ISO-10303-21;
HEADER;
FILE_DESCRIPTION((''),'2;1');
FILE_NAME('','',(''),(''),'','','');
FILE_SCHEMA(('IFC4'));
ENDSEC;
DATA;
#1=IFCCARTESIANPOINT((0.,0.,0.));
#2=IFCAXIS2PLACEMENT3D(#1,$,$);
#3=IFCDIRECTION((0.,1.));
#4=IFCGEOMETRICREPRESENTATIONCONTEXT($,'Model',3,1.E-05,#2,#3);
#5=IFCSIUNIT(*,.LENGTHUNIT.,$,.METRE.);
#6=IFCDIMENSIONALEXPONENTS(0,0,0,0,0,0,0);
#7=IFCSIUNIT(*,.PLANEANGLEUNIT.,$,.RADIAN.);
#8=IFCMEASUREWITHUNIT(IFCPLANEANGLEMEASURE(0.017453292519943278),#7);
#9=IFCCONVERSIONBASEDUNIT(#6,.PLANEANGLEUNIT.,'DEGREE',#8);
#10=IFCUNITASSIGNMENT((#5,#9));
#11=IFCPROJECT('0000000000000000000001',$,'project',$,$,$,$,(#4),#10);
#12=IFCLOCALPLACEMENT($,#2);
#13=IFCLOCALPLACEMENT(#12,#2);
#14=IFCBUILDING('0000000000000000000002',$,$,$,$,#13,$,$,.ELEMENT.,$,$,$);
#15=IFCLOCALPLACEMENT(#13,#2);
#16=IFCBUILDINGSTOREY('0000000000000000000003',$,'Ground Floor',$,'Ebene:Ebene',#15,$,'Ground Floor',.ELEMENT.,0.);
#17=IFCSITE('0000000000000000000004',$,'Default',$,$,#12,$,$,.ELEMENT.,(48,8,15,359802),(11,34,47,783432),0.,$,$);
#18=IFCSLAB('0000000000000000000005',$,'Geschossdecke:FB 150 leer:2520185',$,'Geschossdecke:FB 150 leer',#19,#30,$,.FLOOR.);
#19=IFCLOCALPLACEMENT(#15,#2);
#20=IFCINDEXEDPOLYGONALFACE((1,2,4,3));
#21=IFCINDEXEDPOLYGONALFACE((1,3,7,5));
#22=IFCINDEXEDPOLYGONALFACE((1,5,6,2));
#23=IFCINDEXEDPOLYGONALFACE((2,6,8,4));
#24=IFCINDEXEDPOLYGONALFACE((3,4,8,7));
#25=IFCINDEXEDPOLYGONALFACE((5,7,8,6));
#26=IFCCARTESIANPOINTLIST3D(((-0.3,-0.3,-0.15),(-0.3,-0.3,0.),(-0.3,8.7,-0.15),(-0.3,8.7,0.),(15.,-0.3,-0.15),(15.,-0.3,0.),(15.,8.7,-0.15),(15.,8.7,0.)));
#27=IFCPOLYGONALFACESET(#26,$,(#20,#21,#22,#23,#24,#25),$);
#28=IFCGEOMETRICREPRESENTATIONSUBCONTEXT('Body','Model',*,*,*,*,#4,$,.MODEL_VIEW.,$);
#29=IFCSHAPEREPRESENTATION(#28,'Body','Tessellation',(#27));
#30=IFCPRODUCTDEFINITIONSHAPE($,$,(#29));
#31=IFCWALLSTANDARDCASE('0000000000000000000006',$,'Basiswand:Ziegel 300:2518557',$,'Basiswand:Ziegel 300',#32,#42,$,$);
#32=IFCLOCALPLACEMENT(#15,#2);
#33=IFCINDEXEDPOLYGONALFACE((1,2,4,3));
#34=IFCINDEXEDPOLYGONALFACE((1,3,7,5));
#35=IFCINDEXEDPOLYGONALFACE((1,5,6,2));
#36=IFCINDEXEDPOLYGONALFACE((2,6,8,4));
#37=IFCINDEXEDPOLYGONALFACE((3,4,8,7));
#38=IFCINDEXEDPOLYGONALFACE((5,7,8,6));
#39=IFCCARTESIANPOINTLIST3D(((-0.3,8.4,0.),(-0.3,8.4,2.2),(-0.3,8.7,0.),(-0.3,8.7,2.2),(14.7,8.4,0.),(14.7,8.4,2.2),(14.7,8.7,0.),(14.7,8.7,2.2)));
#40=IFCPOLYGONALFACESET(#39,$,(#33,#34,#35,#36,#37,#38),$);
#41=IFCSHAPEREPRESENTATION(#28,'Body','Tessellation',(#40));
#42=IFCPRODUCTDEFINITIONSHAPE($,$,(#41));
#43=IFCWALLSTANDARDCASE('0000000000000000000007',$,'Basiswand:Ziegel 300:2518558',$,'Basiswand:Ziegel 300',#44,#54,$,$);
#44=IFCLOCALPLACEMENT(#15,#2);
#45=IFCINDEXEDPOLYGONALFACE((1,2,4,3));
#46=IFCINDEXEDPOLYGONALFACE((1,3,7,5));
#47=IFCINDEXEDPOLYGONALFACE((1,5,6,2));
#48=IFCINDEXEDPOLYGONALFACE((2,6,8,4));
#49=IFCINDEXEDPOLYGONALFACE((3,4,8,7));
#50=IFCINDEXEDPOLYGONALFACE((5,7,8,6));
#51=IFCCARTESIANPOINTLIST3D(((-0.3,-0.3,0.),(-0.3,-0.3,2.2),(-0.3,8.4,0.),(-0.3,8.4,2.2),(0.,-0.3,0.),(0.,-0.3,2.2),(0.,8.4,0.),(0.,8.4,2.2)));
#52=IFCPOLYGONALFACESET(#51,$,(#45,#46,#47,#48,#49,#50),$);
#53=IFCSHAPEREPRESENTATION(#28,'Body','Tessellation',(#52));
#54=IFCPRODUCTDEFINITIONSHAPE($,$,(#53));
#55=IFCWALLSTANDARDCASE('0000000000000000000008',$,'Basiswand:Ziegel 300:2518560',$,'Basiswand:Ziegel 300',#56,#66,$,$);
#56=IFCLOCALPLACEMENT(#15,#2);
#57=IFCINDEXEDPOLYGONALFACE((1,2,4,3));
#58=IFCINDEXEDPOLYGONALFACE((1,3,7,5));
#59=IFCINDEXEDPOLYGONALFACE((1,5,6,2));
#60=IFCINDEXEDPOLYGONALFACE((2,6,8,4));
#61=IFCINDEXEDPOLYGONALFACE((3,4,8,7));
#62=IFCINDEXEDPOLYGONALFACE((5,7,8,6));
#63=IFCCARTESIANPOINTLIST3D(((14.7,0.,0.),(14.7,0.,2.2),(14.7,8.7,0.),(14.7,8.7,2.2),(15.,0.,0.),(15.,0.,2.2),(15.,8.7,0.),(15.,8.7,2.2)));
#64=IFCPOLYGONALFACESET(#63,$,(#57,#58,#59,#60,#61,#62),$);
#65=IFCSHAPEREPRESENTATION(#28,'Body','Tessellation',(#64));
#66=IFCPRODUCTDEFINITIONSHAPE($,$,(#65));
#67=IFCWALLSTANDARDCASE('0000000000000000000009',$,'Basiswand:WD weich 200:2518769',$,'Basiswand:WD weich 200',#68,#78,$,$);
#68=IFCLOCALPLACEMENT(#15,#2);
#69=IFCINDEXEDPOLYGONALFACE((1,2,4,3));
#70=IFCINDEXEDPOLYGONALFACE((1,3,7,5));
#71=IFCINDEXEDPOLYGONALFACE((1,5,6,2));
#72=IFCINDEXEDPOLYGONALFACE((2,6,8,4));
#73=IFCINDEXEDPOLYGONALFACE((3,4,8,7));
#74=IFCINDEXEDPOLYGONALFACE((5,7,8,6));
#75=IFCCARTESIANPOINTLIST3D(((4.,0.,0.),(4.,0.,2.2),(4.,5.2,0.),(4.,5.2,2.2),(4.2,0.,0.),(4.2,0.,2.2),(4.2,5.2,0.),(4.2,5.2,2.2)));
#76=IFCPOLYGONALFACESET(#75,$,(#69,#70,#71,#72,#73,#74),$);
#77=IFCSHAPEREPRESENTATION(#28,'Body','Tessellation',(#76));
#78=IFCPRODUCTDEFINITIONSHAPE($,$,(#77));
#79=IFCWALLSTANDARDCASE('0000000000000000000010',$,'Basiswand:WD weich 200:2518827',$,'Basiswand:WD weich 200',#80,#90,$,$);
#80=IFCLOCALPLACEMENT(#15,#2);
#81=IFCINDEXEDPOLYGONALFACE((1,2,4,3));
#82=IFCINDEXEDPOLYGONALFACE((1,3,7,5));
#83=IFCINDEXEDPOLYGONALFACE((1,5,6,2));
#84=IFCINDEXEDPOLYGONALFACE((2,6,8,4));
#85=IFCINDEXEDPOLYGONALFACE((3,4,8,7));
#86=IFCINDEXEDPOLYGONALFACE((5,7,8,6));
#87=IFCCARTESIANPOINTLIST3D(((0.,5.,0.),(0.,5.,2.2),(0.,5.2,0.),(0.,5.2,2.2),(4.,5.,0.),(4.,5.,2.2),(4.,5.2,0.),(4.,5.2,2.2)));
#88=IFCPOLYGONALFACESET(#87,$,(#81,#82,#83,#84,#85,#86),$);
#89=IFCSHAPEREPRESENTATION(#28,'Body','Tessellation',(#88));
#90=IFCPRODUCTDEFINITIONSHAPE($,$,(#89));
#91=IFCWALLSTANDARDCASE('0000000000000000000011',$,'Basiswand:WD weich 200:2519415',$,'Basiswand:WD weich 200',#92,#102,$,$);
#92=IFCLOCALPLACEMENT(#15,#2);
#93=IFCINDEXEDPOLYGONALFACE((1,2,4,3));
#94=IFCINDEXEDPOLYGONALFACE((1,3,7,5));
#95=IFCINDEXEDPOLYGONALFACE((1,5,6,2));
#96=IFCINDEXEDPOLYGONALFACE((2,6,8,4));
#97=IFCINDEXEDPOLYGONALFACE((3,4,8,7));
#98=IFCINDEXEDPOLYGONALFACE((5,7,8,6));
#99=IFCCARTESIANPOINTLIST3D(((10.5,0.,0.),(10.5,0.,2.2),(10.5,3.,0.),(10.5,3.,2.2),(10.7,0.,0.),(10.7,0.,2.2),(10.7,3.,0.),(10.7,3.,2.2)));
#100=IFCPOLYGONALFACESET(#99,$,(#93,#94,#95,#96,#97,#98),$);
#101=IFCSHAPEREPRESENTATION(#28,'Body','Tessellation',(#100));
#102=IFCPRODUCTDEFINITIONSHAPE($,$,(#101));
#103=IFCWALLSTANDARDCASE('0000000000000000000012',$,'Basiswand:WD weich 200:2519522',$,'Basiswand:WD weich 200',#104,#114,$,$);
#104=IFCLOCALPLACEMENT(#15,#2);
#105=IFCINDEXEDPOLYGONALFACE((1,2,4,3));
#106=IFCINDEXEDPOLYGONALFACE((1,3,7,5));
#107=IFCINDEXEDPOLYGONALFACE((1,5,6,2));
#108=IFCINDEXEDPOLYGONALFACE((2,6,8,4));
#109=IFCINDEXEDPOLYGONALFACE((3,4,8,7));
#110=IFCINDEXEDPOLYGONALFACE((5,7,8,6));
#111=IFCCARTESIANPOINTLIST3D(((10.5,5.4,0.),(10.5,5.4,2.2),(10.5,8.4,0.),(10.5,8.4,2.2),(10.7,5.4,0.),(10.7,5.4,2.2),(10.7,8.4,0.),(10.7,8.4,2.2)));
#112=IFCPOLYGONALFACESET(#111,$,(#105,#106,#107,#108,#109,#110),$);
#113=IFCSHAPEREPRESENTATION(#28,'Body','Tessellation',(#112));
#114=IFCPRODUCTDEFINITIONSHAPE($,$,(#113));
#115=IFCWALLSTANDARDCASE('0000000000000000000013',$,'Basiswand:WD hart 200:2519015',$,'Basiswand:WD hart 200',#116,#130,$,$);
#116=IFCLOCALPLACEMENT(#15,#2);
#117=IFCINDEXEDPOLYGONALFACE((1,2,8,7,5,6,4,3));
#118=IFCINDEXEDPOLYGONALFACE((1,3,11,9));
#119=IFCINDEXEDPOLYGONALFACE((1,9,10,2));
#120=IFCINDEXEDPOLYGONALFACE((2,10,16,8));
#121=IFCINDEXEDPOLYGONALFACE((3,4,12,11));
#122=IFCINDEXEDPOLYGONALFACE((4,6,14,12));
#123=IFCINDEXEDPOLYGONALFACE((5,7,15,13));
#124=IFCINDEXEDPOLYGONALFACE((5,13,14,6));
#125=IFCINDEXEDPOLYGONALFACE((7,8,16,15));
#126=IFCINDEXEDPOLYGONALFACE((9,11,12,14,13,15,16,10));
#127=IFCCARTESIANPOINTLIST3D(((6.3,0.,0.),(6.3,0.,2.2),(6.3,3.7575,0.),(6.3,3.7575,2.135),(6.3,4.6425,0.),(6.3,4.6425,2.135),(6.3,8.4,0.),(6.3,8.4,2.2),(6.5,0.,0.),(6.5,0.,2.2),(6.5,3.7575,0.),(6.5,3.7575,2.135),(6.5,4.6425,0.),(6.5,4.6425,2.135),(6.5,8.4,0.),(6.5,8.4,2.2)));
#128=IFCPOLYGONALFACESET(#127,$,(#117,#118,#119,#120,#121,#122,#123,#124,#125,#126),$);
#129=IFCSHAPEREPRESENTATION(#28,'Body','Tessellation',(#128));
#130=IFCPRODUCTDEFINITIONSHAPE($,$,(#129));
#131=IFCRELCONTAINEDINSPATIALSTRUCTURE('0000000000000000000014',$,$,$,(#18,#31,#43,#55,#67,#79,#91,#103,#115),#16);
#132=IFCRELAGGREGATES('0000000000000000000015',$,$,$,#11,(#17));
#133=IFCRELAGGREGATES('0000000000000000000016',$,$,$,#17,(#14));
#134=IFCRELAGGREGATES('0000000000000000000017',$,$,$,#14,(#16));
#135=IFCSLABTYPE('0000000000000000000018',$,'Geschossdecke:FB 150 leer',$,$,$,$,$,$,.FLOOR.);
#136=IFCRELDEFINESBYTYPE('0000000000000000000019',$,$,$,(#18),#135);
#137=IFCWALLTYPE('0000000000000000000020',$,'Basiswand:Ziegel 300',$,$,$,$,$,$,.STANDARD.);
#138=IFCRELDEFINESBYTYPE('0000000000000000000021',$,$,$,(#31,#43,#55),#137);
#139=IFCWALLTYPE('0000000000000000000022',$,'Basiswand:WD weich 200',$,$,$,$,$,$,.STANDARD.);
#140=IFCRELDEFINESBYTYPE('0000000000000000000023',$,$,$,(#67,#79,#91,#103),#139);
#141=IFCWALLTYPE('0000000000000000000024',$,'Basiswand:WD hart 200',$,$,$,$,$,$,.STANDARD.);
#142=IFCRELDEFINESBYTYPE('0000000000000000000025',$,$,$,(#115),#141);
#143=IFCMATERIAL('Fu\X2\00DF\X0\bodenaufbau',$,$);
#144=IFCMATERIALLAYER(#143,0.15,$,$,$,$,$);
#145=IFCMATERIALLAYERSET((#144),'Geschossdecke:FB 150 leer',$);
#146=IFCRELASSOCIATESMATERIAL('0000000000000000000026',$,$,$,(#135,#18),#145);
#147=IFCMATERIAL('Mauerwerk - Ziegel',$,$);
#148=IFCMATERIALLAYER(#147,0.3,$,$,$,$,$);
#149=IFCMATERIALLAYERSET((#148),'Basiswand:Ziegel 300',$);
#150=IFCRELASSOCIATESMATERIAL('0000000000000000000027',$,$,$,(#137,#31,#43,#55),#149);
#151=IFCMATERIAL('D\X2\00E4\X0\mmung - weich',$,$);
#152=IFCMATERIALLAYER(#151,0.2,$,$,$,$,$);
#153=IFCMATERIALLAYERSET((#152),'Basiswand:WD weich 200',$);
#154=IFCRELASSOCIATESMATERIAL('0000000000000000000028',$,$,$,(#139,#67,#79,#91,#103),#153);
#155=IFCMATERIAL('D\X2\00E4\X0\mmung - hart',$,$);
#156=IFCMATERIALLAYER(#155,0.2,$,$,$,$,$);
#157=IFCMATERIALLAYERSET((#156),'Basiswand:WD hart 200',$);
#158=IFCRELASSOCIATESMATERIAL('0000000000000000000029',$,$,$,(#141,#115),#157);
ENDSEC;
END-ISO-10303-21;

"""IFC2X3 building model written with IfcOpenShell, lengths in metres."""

from ifc_helpers import new_model, entity, si_unit, converted_unit, direction, frame, frame_2d, origin, origin_2d_with_axis, place, context, subcontext, project, spatial, rectangle, extrude, material, layer, layer_set, layer_usage, type_object, element, save


model = new_model("IFC2X3")

# Units and contexts
model_context = context("Model", 3, precision=1e-05, world=origin(), true_north=direction((0.0, 1.0)))
body_context = subcontext(model_context, "Body", "Model", "MODEL_VIEW")
ifc_project = project(units=[si_unit("LENGTHUNIT", "METRE"), converted_unit("PLANEANGLEUNIT", "DEGREE", entity("IfcPlaneAngleMeasure", 0.017453292519943278), si_unit("PLANEANGLEUNIT", "RADIAN"), dimensions=[0, 0, 0, 0, 0, 0, 0])], contexts=[model_context])

# Site, building, storey
site_placement = place(None, origin())
site = spatial("IfcSite", under=ifc_project, at=site_placement, Name="Default", CompositionType="ELEMENT", RefLatitude=(48, 8, 15, 359802), RefLongitude=(11, 34, 47, 783432), RefElevation=0.0)
building_placement = place(site_placement, origin())
building = spatial("IfcBuilding", under=site, at=building_placement, CompositionType="ELEMENT")
storey_placement = place(building_placement, origin())
storey = spatial("IfcBuildingStorey", under=building, at=storey_placement, Name="Ground Floor", ObjectType="Ebene:Ebene", LongName="Ground Floor", CompositionType="ELEMENT", Elevation=0.0)

# Slab
ifc_material_1 = material(Name="Fußbodenaufbau")
ifc_layer_1 = layer(ifc_material_1, 0.15)
ifc_layer_set_1 = layer_set([ifc_layer_1], Name="Geschossdecke:FB 150 leer")
ifc_layer_usage_1 = layer_usage(ifc_layer_set_1, "AXIS3", "POSITIVE", 0.0)
slab_type = type_object("IfcSlabType", Name="Geschossdecke:FB 150 leer", PredefinedType="FLOOR", material=ifc_layer_set_1)
slab_placement = place(storey_placement, origin())
element("IfcSlab", 1, at=slab_placement, inside=storey, type_object=slab_type, material=ifc_layer_usage_1, Name="Geschossdecke:FB 150 leer:2520185", ObjectType="Geschossdecke:FB 150 leer", PredefinedType="FLOOR", context=body_context, shape_type="SweptSolid", body=[
    extrude(rectangle(XDim=9.0, YDim=15.3, at=origin_2d_with_axis()), frame((7.35, 4.2, 0.0), z_axis=(0.0, 0.0, -1.0), x_axis=(0.0, 1.0, 0.0)), (0.0, 0.0, 1.0), 0.15),
])

# Walls
ifc_material_2 = material(Name="Mauerwerk - Ziegel")
ifc_layer_2 = layer(ifc_material_2, 0.3)
ifc_layer_set_2 = layer_set([ifc_layer_2], Name="Basiswand:Ziegel 300")
ifc_layer_usage_2 = layer_usage(ifc_layer_set_2, "AXIS2", "NEGATIVE", 0.15)
wall_type_1 = type_object("IfcWallType", Name="Basiswand:Ziegel 300", PredefinedType="STANDARD", material=ifc_layer_set_2)
wall_1_placement = place(storey_placement, frame((-0.3, 8.55, 0.0)))
element("IfcWallStandardCase", 2, at=wall_1_placement, inside=storey, type_object=wall_type_1, material=ifc_layer_usage_2, Name="Basiswand:Ziegel 300:2518557", ObjectType="Basiswand:Ziegel 300", context=body_context, shape_type="SweptSolid", body=[
    extrude(rectangle(XDim=15.0, YDim=0.3, at=frame_2d((7.5, 0.0), x_axis=(-1.0, 0.0))), origin(), (0.0, 0.0, 1.0), 2.2),
])
ifc_layer_usage_3 = layer_usage(ifc_layer_set_2, "AXIS2", "NEGATIVE", 0.15)
wall_2_placement = place(storey_placement, frame((-0.15, -0.3, 0.0), z_axis=(0.0, 0.0, 1.0), x_axis=(0.0, 1.0, 0.0)))
element("IfcWallStandardCase", 3, at=wall_2_placement, inside=storey, type_object=wall_type_1, material=ifc_layer_usage_3, Name="Basiswand:Ziegel 300:2518558", ObjectType="Basiswand:Ziegel 300", context=body_context, shape_type="SweptSolid", body=[
    extrude(rectangle(XDim=8.7, YDim=0.3, at=frame_2d((4.35, 0.0), x_axis=(-1.0, 0.0))), origin(), (0.0, 0.0, 1.0), 2.2),
])
ifc_layer_usage_4 = layer_usage(ifc_layer_set_2, "AXIS2", "NEGATIVE", 0.15)
wall_3_placement = place(storey_placement, frame((14.85, 8.7, 0.0), z_axis=(0.0, 0.0, 1.0), x_axis=(0.0, -1.0, 0.0)))
element("IfcWallStandardCase", 4, at=wall_3_placement, inside=storey, type_object=wall_type_1, material=ifc_layer_usage_4, Name="Basiswand:Ziegel 300:2518560", ObjectType="Basiswand:Ziegel 300", context=body_context, shape_type="SweptSolid", body=[
    extrude(rectangle(XDim=8.7, YDim=0.3, at=frame_2d((4.35, 0.0), x_axis=(-1.0, 0.0))), origin(), (0.0, 0.0, 1.0), 2.2),
])
ifc_material_3 = material(Name="Dämmung - weich")
ifc_layer_3 = layer(ifc_material_3, 0.2)
ifc_layer_set_3 = layer_set([ifc_layer_3], Name="Basiswand:WD weich 200")
ifc_layer_usage_5 = layer_usage(ifc_layer_set_3, "AXIS2", "NEGATIVE", 0.1)
wall_type_2 = type_object("IfcWallType", Name="Basiswand:WD weich 200", PredefinedType="STANDARD", material=ifc_layer_set_3)
wall_4_placement = place(storey_placement, frame((4.1, 0.0, 0.0), z_axis=(0.0, 0.0, 1.0), x_axis=(0.0, 1.0, 0.0)))
element("IfcWallStandardCase", 5, at=wall_4_placement, inside=storey, type_object=wall_type_2, material=ifc_layer_usage_5, Name="Basiswand:WD weich 200:2518769", ObjectType="Basiswand:WD weich 200", context=body_context, shape_type="SweptSolid", body=[
    extrude(rectangle(XDim=5.2, YDim=0.2, at=frame_2d((2.6, 0.0), x_axis=(-1.0, 0.0))), origin(), (0.0, 0.0, 1.0), 2.2),
])
ifc_layer_usage_6 = layer_usage(ifc_layer_set_3, "AXIS2", "NEGATIVE", 0.1)
wall_5_placement = place(storey_placement, frame((4.0, 5.1, 0.0), z_axis=(0.0, 0.0, 1.0), x_axis=(-1.0, 0.0, 0.0)))
element("IfcWallStandardCase", 6, at=wall_5_placement, inside=storey, type_object=wall_type_2, material=ifc_layer_usage_6, Name="Basiswand:WD weich 200:2518827", ObjectType="Basiswand:WD weich 200", context=body_context, shape_type="SweptSolid", body=[
    extrude(rectangle(XDim=4.0, YDim=0.2, at=frame_2d((2.0, 0.0), x_axis=(-1.0, 0.0))), origin(), (0.0, 0.0, 1.0), 2.2),
])
ifc_layer_usage_7 = layer_usage(ifc_layer_set_3, "AXIS2", "NEGATIVE", 0.1)
wall_6_placement = place(storey_placement, frame((10.6, 3.0, 0.0), z_axis=(0.0, 0.0, 1.0), x_axis=(0.0, -1.0, 0.0)))
element("IfcWallStandardCase", 7, at=wall_6_placement, inside=storey, type_object=wall_type_2, material=ifc_layer_usage_7, Name="Basiswand:WD weich 200:2519415", ObjectType="Basiswand:WD weich 200", context=body_context, shape_type="SweptSolid", body=[
    extrude(rectangle(XDim=3.0, YDim=0.2, at=frame_2d((1.5, 0.0), x_axis=(-1.0, 0.0))), origin(), (0.0, 0.0, 1.0), 2.2),
])
ifc_layer_usage_8 = layer_usage(ifc_layer_set_3, "AXIS2", "NEGATIVE", 0.1)
wall_7_placement = place(storey_placement, frame((10.6, 5.4, 0.0), z_axis=(0.0, 0.0, 1.0), x_axis=(0.0, 1.0, 0.0)))
element("IfcWallStandardCase", 8, at=wall_7_placement, inside=storey, type_object=wall_type_2, material=ifc_layer_usage_8, Name="Basiswand:WD weich 200:2519522", ObjectType="Basiswand:WD weich 200", context=body_context, shape_type="SweptSolid", body=[
    extrude(rectangle(XDim=3.0, YDim=0.2, at=frame_2d((1.5, 0.0), x_axis=(-1.0, 0.0))), origin(), (0.0, 0.0, 1.0), 2.2),
])

# Wall, opening
ifc_material_4 = material(Name="Dämmung - hart")
ifc_layer_4 = layer(ifc_material_4, 0.2)
ifc_layer_set_4 = layer_set([ifc_layer_4], Name="Basiswand:WD hart 200")
ifc_layer_usage_9 = layer_usage(ifc_layer_set_4, "AXIS2", "NEGATIVE", 0.1)
wall_type_3 = type_object("IfcWallType", Name="Basiswand:WD hart 200", PredefinedType="STANDARD", material=ifc_layer_set_4)
wall_8_placement = place(storey_placement, frame((6.4, 8.4, 0.0), z_axis=(0.0, 0.0, 1.0), x_axis=(0.0, -1.0, 0.0)))
wall_8 = element("IfcWallStandardCase", 9, at=wall_8_placement, inside=storey, type_object=wall_type_3, material=ifc_layer_usage_9, Name="Basiswand:WD hart 200:2519015", ObjectType="Basiswand:WD hart 200", context=body_context, shape_type="SweptSolid", body=[
    extrude(rectangle(XDim=8.4, YDim=0.2, at=frame_2d((4.2, 0.0), x_axis=(1.0, 0.0))), origin(), (0.0, 0.0, 1.0), 2.2),
])
opening_1_placement = place(wall_8_placement, frame((3.7575, -0.1, -0.18)))
element("IfcOpeningElement", 10, at=opening_1_placement, cuts=wall_8, ObjectType="Opening", context=body_context, shape_type="SweptSolid", body=[
    extrude(rectangle(XDim=2.315, YDim=0.885, at=frame_2d((1.1575, 0.4425), x_axis=(-1.0, 0.0))), frame((0.0, 0.0, 0.0), z_axis=(0.0, 1.0, 0.0), x_axis=(0.0, 0.0, 1.0)), (0.0, 0.0, 1.0), 0.2),
])

save(model, "model.ifc")
